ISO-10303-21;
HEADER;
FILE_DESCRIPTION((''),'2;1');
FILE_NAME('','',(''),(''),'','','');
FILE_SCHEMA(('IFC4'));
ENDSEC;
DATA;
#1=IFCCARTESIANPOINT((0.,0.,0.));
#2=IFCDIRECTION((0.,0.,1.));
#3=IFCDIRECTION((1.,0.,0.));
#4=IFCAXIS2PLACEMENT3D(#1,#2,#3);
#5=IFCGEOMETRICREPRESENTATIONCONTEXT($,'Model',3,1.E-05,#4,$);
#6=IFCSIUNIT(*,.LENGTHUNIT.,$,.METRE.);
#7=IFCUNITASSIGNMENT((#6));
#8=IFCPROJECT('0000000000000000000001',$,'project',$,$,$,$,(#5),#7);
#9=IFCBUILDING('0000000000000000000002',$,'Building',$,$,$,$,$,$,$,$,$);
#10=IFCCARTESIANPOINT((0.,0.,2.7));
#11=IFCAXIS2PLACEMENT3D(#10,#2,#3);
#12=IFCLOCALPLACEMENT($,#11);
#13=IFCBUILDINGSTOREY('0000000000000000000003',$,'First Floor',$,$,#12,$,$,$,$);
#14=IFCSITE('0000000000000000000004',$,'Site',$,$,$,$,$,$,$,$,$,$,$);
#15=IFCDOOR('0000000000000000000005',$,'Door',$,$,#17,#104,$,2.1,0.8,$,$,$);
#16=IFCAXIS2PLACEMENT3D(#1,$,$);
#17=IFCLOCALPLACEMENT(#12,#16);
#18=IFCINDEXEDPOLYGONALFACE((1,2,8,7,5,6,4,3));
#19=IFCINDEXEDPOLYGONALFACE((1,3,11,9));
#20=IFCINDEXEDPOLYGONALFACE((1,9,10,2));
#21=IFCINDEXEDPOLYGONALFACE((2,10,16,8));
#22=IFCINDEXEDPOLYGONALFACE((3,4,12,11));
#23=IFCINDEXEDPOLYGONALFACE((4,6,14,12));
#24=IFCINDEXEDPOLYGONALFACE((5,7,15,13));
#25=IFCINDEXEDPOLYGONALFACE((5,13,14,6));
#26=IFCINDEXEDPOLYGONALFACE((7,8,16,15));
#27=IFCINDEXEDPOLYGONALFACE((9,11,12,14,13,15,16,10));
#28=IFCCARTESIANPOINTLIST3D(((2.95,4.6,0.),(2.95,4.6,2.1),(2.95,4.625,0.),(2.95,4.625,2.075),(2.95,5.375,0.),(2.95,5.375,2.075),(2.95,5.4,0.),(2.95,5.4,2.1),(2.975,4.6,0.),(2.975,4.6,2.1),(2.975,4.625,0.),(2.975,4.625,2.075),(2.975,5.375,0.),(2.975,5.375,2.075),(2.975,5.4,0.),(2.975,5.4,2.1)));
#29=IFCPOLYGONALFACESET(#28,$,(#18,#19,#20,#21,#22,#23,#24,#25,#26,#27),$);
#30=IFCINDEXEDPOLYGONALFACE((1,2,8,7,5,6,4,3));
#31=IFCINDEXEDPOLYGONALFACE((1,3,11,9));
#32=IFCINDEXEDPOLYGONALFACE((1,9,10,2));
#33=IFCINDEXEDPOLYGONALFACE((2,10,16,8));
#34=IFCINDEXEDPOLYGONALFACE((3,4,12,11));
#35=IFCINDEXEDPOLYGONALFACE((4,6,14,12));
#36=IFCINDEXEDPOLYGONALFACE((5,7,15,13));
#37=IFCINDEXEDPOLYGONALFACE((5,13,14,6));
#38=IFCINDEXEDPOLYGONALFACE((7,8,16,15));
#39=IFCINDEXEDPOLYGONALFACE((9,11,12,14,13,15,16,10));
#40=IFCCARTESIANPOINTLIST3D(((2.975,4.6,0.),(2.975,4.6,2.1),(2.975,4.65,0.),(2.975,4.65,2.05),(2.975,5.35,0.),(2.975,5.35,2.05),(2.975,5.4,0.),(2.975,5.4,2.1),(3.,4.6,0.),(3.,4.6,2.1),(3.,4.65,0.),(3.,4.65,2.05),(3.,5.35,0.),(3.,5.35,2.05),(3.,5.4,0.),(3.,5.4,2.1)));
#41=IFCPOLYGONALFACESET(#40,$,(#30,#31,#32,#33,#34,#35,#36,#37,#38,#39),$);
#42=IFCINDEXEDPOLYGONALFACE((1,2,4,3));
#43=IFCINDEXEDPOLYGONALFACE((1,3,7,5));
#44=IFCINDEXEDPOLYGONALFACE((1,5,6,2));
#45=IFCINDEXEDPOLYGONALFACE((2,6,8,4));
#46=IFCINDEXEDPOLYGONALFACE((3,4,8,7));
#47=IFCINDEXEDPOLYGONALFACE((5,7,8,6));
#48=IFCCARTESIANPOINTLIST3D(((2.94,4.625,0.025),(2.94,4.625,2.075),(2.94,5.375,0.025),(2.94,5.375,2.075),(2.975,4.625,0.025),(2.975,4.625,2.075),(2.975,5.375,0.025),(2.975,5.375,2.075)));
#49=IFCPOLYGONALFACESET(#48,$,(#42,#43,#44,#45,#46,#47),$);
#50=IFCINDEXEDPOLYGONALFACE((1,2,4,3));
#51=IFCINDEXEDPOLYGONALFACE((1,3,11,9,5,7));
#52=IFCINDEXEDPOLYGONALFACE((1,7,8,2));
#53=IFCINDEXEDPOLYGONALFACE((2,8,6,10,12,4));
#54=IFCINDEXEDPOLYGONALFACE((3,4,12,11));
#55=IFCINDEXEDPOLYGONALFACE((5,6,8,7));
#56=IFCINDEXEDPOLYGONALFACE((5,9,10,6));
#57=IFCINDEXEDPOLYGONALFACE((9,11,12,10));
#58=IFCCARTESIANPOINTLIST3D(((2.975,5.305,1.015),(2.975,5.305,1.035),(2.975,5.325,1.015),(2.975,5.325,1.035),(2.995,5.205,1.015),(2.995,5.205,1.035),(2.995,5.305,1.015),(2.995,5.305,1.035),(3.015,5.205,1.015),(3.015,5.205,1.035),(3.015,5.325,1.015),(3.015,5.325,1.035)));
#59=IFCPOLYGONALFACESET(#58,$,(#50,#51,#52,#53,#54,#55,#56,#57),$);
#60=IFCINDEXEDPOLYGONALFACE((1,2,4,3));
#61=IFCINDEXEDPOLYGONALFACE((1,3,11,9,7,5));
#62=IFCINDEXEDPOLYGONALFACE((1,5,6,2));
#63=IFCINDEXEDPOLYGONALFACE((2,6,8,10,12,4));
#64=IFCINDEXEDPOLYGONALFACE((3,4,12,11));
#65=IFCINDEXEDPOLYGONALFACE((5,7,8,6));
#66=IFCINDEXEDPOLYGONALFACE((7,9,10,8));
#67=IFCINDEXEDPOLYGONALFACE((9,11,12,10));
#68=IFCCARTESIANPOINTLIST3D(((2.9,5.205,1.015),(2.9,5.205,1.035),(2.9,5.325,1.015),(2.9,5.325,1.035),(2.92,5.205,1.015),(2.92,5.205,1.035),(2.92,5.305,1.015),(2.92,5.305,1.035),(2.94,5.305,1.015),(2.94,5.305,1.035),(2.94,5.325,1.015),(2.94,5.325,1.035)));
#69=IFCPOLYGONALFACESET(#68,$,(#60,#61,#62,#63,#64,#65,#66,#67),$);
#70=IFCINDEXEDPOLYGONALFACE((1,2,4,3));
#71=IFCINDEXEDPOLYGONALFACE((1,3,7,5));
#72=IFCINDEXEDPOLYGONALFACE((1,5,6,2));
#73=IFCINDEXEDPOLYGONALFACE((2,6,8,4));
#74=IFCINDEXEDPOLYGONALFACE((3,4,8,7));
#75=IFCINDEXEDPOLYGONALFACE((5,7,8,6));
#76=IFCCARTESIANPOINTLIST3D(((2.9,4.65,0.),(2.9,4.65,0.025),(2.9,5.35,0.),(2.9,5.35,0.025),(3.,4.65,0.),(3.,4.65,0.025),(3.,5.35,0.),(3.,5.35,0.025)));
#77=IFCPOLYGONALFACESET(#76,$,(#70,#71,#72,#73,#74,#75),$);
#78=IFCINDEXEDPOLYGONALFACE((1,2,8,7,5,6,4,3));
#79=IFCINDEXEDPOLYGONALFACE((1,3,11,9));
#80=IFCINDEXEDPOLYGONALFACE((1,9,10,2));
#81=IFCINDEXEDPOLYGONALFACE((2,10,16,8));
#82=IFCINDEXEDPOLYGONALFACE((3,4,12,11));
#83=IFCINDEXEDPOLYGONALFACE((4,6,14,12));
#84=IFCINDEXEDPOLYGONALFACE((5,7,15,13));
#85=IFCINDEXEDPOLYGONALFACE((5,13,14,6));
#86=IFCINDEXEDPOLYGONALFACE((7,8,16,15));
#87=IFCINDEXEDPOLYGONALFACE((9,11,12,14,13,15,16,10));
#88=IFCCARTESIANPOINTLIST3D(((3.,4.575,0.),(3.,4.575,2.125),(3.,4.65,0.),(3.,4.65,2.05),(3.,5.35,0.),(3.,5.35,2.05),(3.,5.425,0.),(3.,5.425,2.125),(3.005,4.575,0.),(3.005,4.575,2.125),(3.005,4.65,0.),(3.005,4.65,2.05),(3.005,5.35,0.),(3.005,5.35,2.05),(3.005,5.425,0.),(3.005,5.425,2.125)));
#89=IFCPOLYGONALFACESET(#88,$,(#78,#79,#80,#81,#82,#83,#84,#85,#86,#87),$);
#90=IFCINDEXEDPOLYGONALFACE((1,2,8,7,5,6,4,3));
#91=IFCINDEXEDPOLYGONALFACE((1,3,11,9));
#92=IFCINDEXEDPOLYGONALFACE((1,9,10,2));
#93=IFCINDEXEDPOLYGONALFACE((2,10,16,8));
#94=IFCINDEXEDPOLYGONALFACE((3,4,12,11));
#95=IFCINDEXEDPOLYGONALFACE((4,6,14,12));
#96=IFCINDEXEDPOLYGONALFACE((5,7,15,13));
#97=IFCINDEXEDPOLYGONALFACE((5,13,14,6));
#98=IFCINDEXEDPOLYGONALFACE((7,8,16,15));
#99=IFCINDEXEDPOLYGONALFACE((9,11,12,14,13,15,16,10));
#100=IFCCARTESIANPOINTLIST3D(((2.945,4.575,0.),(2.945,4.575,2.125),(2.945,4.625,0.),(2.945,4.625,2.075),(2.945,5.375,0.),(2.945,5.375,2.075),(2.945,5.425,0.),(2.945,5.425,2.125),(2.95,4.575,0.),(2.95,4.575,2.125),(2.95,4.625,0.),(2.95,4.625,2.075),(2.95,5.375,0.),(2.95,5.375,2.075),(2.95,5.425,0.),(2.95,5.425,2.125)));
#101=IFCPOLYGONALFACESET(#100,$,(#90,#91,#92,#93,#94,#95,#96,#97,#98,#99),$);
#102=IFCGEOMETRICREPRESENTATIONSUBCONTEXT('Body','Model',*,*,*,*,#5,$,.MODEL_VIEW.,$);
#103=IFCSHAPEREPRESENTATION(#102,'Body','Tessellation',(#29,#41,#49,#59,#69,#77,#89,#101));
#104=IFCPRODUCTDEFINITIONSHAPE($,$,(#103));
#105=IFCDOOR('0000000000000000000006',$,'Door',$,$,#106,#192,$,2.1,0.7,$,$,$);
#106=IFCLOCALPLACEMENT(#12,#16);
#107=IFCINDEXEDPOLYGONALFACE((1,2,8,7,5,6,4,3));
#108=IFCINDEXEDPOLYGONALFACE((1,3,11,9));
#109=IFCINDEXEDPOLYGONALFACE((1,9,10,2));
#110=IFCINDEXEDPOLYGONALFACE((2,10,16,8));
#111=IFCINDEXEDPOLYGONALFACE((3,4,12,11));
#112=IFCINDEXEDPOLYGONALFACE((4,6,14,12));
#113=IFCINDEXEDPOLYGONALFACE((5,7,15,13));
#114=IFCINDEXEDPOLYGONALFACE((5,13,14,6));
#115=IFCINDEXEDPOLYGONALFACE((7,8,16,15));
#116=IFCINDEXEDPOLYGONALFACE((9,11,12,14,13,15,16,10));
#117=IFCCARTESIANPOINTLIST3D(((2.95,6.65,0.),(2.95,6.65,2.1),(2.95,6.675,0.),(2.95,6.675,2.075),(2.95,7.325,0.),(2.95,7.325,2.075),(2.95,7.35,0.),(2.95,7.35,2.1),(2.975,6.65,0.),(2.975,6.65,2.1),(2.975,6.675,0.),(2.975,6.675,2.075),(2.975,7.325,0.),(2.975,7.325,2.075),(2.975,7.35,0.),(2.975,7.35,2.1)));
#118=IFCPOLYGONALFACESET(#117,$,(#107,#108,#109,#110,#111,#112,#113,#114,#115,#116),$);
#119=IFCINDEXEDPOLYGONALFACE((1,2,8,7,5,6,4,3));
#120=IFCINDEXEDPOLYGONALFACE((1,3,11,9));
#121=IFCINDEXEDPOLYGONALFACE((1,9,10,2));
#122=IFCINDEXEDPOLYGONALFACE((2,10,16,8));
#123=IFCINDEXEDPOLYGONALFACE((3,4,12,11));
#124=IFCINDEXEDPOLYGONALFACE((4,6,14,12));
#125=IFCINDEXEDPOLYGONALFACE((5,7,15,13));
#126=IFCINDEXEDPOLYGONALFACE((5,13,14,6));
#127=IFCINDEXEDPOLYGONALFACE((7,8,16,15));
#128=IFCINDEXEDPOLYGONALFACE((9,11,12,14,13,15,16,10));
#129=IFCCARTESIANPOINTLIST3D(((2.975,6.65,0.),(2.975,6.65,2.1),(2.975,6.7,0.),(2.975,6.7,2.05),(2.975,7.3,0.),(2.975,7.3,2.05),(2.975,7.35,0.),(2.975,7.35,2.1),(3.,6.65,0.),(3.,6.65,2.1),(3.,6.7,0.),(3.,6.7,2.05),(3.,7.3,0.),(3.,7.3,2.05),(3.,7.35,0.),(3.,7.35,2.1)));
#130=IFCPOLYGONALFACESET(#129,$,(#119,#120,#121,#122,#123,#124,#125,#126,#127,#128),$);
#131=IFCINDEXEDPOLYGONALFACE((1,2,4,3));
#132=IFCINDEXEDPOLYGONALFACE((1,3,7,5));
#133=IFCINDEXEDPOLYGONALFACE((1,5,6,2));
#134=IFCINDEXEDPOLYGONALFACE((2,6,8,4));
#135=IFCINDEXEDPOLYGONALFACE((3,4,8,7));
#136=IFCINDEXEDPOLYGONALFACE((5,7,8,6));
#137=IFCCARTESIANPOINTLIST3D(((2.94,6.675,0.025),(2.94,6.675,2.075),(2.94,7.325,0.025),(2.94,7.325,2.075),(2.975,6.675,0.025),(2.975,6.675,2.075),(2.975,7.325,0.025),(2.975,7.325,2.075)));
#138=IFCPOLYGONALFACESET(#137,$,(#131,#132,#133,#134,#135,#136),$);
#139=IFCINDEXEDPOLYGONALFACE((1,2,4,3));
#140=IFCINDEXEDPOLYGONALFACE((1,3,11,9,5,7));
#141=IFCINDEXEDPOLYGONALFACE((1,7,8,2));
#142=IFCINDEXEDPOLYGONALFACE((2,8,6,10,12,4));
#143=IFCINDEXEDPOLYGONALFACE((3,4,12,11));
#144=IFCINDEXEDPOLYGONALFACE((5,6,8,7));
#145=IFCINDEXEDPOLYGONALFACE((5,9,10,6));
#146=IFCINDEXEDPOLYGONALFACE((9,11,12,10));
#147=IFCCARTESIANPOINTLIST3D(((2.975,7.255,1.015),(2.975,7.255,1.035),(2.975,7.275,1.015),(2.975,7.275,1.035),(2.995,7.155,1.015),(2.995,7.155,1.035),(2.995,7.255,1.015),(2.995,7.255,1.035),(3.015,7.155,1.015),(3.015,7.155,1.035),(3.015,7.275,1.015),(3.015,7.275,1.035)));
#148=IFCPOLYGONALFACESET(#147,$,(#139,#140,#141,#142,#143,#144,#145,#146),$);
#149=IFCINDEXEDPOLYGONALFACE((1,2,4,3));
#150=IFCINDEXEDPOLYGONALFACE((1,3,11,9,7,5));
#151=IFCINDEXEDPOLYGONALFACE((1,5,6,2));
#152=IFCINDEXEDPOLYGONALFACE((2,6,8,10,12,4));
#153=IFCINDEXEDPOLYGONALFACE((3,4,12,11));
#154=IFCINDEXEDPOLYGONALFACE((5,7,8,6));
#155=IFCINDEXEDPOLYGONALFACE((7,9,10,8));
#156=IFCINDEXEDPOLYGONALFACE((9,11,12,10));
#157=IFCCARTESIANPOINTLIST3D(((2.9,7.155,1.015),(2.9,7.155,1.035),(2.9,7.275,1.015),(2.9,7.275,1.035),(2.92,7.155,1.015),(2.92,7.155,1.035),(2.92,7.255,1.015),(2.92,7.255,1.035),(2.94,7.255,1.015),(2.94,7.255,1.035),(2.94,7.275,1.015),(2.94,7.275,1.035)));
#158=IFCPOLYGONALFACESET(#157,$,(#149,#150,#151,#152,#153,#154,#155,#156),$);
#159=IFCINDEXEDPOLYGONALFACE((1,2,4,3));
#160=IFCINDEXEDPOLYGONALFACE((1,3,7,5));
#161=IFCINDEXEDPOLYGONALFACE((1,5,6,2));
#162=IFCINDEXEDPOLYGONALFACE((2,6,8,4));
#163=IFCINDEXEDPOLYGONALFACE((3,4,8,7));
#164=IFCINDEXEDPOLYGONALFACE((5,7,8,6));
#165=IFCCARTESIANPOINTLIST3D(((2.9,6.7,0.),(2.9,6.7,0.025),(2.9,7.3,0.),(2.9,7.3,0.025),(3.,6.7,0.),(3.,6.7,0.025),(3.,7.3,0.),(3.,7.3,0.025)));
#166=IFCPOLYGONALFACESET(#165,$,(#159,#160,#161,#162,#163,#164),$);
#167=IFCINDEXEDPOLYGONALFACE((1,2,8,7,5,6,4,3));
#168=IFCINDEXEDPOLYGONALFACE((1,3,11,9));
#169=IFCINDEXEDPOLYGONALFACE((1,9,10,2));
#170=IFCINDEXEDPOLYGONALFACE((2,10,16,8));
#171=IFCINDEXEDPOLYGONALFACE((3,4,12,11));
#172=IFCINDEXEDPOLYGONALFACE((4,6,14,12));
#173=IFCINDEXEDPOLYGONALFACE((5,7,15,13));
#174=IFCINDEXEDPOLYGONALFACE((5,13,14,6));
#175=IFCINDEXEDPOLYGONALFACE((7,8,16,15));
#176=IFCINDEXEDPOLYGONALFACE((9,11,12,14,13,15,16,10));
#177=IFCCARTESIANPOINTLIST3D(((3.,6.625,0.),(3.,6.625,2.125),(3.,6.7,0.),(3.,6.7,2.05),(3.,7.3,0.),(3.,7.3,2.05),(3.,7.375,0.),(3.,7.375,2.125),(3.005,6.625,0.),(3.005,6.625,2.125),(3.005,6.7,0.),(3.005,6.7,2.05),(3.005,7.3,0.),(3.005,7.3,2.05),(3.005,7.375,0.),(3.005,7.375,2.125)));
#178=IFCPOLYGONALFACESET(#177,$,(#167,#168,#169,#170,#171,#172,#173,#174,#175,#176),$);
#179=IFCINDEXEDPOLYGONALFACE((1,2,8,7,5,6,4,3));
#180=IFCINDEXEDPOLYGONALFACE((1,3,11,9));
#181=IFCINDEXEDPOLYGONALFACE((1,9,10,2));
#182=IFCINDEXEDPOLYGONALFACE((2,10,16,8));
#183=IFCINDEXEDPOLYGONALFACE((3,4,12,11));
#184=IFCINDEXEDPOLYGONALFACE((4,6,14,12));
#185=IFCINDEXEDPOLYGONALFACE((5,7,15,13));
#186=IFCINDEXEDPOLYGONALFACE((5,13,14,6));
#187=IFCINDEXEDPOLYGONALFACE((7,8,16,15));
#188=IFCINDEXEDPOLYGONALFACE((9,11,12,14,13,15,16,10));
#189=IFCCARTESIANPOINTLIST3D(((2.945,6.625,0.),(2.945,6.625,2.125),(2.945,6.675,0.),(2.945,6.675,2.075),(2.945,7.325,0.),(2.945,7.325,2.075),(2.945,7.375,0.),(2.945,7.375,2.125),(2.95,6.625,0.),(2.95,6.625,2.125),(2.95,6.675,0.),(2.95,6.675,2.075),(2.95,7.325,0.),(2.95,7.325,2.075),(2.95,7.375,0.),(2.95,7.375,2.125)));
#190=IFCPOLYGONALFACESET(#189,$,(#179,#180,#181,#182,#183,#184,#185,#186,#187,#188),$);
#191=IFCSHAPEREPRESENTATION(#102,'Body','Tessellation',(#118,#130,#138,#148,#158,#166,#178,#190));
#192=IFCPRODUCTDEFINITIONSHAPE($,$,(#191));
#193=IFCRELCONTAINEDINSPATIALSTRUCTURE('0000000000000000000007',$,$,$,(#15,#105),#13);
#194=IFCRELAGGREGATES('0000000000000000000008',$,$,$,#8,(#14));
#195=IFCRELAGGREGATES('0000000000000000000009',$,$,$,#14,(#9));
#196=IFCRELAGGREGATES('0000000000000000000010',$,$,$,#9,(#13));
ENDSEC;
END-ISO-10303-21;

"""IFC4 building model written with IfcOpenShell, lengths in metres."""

from ifc_helpers import new_model, si_unit, frame, origin_with_axes, place, context, subcontext, project, spatial, line, indexed_curve, outline, extrude, element, save


model = new_model("IFC4")

# Units and contexts
model_context = context("Model", 3, precision=1e-05, world=origin_with_axes())
body_context = subcontext(model_context, "Body", "Model", "MODEL_VIEW")
ifc_project = project(units=[si_unit("LENGTHUNIT", "METRE")], contexts=[model_context])

# Site, building, storey
site = spatial("IfcSite", under=ifc_project, Name="Site")
building = spatial("IfcBuilding", under=site, Name="Building")
storey_placement = place(None, frame((0.0, 0.0, 2.7), z_axis=(0.0, 0.0, 1.0), x_axis=(1.0, 0.0, 0.0)))
storey = spatial("IfcBuildingStorey", under=building, at=storey_placement, Name="First Floor")

# Doors
door_1_placement = place(storey_placement, frame((3.0, 4.6, 0.0), z_axis=(0.0, 0.0, 1.0), x_axis=(0.0, 1.0, 0.0)))
element("IfcDoor", 1, at=door_1_placement, inside=storey, Name="Door", OverallHeight=2.1, OverallWidth=0.8, context=body_context, shape_type="SweptSolid", body=[
    extrude(outline(indexed_curve([(0.0, 0.0), (0.0, 2.1), (0.8, 2.1), (0.8, 0.0), (0.775, 0.0), (0.775, 2.075), (0.025, 2.075), (0.025, 0.0)], segments=[line(1, 2, 3, 4, 5, 6, 7, 8, 1)])), frame((0.0, 0.025, 0.0), z_axis=(0.0, -1.0, 0.0), x_axis=(1.0, 0.0, 0.0)), (0.0, 0.0, -1.0), 0.025),
    extrude(outline(indexed_curve([(0.0, 0.0), (0.0, 2.1), (0.8, 2.1), (0.8, 0.0), (0.75, 0.0), (0.75, 2.05), (0.05, 2.05), (0.05, 0.0)], segments=[line(1, 2, 3, 4, 5, 6, 7, 8, 1)])), frame((0.0, 0.0, 0.0), z_axis=(0.0, -1.0, 0.0), x_axis=(1.0, 0.0, 0.0)), (0.0, 0.0, -1.0), 0.025),
    extrude(outline(indexed_curve([(0.0, 0.0), (0.75, 0.0), (0.75, 0.035), (0.0, 0.035)], segments=[line(1, 2, 3, 4, 1)])), frame((0.025, 0.025, 0.025), z_axis=(0.0, 0.0, 1.0), x_axis=(1.0, 0.0, 0.0)), (0.0, 0.0, 1.0), 2.05),
    extrude(outline(indexed_curve([(0.0, 0.0), (0.0, -0.04), (-0.12, -0.04), (-0.12, -0.02), (-0.02, -0.02), (-0.02, 0.0)], segments=[line(1, 2, 3, 4, 5, 6, 1)])), frame((0.725, 0.025, 1.015), z_axis=(0.0, 0.0, 1.0), x_axis=(1.0, 0.0, 0.0)), (0.0, 0.0, 1.0), 0.02),
    extrude(outline(indexed_curve([(0.0, 0.0), (0.0, 0.04), (-0.12, 0.04), (-0.12, 0.02), (-0.02, 0.02), (-0.02, 0.0)], segments=[line(1, 2, 3, 4, 5, 6, 1)])), frame((0.725, 0.06, 1.015), z_axis=(0.0, 0.0, 1.0), x_axis=(1.0, 0.0, 0.0)), (0.0, 0.0, 1.0), 0.02),
    extrude(outline(indexed_curve([(0.0, 0.0), (0.7, 0.0), (0.7, 0.1), (0.0, 0.1)], segments=[line(1, 2, 3, 4, 1)])), frame((0.05, 0.0, 0.0), z_axis=(0.0, 0.0, 1.0), x_axis=(1.0, 0.0, 0.0)), (0.0, 0.0, 1.0), 0.025),
    extrude(outline(indexed_curve([(0.0, 0.0), (0.0, 2.125), (0.85, 2.125), (0.85, 0.0), (0.775, 0.0), (0.775, 2.05), (0.075, 2.05), (0.075, 0.0)], segments=[line(1, 2, 3, 4, 5, 6, 7, 8, 1)])), frame((-0.025, -0.005, 0.0), z_axis=(0.0, -1.0, 0.0), x_axis=(1.0, 0.0, 0.0)), (0.0, 0.0, -1.0), 0.005),
    extrude(outline(indexed_curve([(0.0, 0.0), (0.0, 2.125), (0.85, 2.125), (0.85, 0.0), (0.8, 0.0), (0.8, 2.075), (0.05, 2.075), (0.05, 0.0)], segments=[line(1, 2, 3, 4, 5, 6, 7, 8, 1)])), frame((-0.025, 0.05, 0.0), z_axis=(0.0, -1.0, 0.0), x_axis=(1.0, 0.0, 0.0)), (0.0, 0.0, -1.0), 0.005),
])
door_2_placement = place(storey_placement, frame((3.0, 6.65, 0.0), z_axis=(0.0, 0.0, 1.0), x_axis=(0.0, 1.0, 0.0)))
element("IfcDoor", 2, at=door_2_placement, inside=storey, Name="Door", OverallHeight=2.1, OverallWidth=0.7, context=body_context, shape_type="SweptSolid", body=[
    extrude(outline(indexed_curve([(0.0, 0.0), (0.0, 2.1), (0.7, 2.1), (0.7, 0.0), (0.675, 0.0), (0.675, 2.075), (0.025, 2.075), (0.025, 0.0)], segments=[line(1, 2, 3, 4, 5, 6, 7, 8, 1)])), frame((0.0, 0.025, 0.0), z_axis=(0.0, -1.0, 0.0), x_axis=(1.0, 0.0, 0.0)), (0.0, 0.0, -1.0), 0.025),
    extrude(outline(indexed_curve([(0.0, 0.0), (0.0, 2.1), (0.7, 2.1), (0.7, 0.0), (0.65, 0.0), (0.65, 2.05), (0.05, 2.05), (0.05, 0.0)], segments=[line(1, 2, 3, 4, 5, 6, 7, 8, 1)])), frame((0.0, 0.0, 0.0), z_axis=(0.0, -1.0, 0.0), x_axis=(1.0, 0.0, 0.0)), (0.0, 0.0, -1.0), 0.025),
    extrude(outline(indexed_curve([(0.0, 0.0), (0.65, 0.0), (0.65, 0.035), (0.0, 0.035)], segments=[line(1, 2, 3, 4, 1)])), frame((0.025, 0.025, 0.025), z_axis=(0.0, 0.0, 1.0), x_axis=(1.0, 0.0, 0.0)), (0.0, 0.0, 1.0), 2.05),
    extrude(outline(indexed_curve([(0.0, 0.0), (0.0, -0.04), (-0.12, -0.04), (-0.12, -0.02), (-0.02, -0.02), (-0.02, 0.0)], segments=[line(1, 2, 3, 4, 5, 6, 1)])), frame((0.625, 0.025, 1.015), z_axis=(0.0, 0.0, 1.0), x_axis=(1.0, 0.0, 0.0)), (0.0, 0.0, 1.0), 0.02),
    extrude(outline(indexed_curve([(0.0, 0.0), (0.0, 0.04), (-0.12, 0.04), (-0.12, 0.02), (-0.02, 0.02), (-0.02, 0.0)], segments=[line(1, 2, 3, 4, 5, 6, 1)])), frame((0.625, 0.06, 1.015), z_axis=(0.0, 0.0, 1.0), x_axis=(1.0, 0.0, 0.0)), (0.0, 0.0, 1.0), 0.02),
    extrude(outline(indexed_curve([(0.0, 0.0), (0.6, 0.0), (0.6, 0.1), (0.0, 0.1)], segments=[line(1, 2, 3, 4, 1)])), frame((0.05, 0.0, 0.0), z_axis=(0.0, 0.0, 1.0), x_axis=(1.0, 0.0, 0.0)), (0.0, 0.0, 1.0), 0.025),
    extrude(outline(indexed_curve([(0.0, 0.0), (0.0, 2.125), (0.75, 2.125), (0.75, 0.0), (0.675, 0.0), (0.675, 2.05), (0.075, 2.05), (0.075, 0.0)], segments=[line(1, 2, 3, 4, 5, 6, 7, 8, 1)])), frame((-0.025, -0.005, 0.0), z_axis=(0.0, -1.0, 0.0), x_axis=(1.0, 0.0, 0.0)), (0.0, 0.0, -1.0), 0.005),
    extrude(outline(indexed_curve([(0.0, 0.0), (0.0, 2.125), (0.75, 2.125), (0.75, 0.0), (0.7, 0.0), (0.7, 2.075), (0.05, 2.075), (0.05, 0.0)], segments=[line(1, 2, 3, 4, 5, 6, 7, 8, 1)])), frame((-0.025, 0.05, 0.0), z_axis=(0.0, -1.0, 0.0), x_axis=(1.0, 0.0, 0.0)), (0.0, 0.0, -1.0), 0.005),
])

save(model, "model.ifc")
